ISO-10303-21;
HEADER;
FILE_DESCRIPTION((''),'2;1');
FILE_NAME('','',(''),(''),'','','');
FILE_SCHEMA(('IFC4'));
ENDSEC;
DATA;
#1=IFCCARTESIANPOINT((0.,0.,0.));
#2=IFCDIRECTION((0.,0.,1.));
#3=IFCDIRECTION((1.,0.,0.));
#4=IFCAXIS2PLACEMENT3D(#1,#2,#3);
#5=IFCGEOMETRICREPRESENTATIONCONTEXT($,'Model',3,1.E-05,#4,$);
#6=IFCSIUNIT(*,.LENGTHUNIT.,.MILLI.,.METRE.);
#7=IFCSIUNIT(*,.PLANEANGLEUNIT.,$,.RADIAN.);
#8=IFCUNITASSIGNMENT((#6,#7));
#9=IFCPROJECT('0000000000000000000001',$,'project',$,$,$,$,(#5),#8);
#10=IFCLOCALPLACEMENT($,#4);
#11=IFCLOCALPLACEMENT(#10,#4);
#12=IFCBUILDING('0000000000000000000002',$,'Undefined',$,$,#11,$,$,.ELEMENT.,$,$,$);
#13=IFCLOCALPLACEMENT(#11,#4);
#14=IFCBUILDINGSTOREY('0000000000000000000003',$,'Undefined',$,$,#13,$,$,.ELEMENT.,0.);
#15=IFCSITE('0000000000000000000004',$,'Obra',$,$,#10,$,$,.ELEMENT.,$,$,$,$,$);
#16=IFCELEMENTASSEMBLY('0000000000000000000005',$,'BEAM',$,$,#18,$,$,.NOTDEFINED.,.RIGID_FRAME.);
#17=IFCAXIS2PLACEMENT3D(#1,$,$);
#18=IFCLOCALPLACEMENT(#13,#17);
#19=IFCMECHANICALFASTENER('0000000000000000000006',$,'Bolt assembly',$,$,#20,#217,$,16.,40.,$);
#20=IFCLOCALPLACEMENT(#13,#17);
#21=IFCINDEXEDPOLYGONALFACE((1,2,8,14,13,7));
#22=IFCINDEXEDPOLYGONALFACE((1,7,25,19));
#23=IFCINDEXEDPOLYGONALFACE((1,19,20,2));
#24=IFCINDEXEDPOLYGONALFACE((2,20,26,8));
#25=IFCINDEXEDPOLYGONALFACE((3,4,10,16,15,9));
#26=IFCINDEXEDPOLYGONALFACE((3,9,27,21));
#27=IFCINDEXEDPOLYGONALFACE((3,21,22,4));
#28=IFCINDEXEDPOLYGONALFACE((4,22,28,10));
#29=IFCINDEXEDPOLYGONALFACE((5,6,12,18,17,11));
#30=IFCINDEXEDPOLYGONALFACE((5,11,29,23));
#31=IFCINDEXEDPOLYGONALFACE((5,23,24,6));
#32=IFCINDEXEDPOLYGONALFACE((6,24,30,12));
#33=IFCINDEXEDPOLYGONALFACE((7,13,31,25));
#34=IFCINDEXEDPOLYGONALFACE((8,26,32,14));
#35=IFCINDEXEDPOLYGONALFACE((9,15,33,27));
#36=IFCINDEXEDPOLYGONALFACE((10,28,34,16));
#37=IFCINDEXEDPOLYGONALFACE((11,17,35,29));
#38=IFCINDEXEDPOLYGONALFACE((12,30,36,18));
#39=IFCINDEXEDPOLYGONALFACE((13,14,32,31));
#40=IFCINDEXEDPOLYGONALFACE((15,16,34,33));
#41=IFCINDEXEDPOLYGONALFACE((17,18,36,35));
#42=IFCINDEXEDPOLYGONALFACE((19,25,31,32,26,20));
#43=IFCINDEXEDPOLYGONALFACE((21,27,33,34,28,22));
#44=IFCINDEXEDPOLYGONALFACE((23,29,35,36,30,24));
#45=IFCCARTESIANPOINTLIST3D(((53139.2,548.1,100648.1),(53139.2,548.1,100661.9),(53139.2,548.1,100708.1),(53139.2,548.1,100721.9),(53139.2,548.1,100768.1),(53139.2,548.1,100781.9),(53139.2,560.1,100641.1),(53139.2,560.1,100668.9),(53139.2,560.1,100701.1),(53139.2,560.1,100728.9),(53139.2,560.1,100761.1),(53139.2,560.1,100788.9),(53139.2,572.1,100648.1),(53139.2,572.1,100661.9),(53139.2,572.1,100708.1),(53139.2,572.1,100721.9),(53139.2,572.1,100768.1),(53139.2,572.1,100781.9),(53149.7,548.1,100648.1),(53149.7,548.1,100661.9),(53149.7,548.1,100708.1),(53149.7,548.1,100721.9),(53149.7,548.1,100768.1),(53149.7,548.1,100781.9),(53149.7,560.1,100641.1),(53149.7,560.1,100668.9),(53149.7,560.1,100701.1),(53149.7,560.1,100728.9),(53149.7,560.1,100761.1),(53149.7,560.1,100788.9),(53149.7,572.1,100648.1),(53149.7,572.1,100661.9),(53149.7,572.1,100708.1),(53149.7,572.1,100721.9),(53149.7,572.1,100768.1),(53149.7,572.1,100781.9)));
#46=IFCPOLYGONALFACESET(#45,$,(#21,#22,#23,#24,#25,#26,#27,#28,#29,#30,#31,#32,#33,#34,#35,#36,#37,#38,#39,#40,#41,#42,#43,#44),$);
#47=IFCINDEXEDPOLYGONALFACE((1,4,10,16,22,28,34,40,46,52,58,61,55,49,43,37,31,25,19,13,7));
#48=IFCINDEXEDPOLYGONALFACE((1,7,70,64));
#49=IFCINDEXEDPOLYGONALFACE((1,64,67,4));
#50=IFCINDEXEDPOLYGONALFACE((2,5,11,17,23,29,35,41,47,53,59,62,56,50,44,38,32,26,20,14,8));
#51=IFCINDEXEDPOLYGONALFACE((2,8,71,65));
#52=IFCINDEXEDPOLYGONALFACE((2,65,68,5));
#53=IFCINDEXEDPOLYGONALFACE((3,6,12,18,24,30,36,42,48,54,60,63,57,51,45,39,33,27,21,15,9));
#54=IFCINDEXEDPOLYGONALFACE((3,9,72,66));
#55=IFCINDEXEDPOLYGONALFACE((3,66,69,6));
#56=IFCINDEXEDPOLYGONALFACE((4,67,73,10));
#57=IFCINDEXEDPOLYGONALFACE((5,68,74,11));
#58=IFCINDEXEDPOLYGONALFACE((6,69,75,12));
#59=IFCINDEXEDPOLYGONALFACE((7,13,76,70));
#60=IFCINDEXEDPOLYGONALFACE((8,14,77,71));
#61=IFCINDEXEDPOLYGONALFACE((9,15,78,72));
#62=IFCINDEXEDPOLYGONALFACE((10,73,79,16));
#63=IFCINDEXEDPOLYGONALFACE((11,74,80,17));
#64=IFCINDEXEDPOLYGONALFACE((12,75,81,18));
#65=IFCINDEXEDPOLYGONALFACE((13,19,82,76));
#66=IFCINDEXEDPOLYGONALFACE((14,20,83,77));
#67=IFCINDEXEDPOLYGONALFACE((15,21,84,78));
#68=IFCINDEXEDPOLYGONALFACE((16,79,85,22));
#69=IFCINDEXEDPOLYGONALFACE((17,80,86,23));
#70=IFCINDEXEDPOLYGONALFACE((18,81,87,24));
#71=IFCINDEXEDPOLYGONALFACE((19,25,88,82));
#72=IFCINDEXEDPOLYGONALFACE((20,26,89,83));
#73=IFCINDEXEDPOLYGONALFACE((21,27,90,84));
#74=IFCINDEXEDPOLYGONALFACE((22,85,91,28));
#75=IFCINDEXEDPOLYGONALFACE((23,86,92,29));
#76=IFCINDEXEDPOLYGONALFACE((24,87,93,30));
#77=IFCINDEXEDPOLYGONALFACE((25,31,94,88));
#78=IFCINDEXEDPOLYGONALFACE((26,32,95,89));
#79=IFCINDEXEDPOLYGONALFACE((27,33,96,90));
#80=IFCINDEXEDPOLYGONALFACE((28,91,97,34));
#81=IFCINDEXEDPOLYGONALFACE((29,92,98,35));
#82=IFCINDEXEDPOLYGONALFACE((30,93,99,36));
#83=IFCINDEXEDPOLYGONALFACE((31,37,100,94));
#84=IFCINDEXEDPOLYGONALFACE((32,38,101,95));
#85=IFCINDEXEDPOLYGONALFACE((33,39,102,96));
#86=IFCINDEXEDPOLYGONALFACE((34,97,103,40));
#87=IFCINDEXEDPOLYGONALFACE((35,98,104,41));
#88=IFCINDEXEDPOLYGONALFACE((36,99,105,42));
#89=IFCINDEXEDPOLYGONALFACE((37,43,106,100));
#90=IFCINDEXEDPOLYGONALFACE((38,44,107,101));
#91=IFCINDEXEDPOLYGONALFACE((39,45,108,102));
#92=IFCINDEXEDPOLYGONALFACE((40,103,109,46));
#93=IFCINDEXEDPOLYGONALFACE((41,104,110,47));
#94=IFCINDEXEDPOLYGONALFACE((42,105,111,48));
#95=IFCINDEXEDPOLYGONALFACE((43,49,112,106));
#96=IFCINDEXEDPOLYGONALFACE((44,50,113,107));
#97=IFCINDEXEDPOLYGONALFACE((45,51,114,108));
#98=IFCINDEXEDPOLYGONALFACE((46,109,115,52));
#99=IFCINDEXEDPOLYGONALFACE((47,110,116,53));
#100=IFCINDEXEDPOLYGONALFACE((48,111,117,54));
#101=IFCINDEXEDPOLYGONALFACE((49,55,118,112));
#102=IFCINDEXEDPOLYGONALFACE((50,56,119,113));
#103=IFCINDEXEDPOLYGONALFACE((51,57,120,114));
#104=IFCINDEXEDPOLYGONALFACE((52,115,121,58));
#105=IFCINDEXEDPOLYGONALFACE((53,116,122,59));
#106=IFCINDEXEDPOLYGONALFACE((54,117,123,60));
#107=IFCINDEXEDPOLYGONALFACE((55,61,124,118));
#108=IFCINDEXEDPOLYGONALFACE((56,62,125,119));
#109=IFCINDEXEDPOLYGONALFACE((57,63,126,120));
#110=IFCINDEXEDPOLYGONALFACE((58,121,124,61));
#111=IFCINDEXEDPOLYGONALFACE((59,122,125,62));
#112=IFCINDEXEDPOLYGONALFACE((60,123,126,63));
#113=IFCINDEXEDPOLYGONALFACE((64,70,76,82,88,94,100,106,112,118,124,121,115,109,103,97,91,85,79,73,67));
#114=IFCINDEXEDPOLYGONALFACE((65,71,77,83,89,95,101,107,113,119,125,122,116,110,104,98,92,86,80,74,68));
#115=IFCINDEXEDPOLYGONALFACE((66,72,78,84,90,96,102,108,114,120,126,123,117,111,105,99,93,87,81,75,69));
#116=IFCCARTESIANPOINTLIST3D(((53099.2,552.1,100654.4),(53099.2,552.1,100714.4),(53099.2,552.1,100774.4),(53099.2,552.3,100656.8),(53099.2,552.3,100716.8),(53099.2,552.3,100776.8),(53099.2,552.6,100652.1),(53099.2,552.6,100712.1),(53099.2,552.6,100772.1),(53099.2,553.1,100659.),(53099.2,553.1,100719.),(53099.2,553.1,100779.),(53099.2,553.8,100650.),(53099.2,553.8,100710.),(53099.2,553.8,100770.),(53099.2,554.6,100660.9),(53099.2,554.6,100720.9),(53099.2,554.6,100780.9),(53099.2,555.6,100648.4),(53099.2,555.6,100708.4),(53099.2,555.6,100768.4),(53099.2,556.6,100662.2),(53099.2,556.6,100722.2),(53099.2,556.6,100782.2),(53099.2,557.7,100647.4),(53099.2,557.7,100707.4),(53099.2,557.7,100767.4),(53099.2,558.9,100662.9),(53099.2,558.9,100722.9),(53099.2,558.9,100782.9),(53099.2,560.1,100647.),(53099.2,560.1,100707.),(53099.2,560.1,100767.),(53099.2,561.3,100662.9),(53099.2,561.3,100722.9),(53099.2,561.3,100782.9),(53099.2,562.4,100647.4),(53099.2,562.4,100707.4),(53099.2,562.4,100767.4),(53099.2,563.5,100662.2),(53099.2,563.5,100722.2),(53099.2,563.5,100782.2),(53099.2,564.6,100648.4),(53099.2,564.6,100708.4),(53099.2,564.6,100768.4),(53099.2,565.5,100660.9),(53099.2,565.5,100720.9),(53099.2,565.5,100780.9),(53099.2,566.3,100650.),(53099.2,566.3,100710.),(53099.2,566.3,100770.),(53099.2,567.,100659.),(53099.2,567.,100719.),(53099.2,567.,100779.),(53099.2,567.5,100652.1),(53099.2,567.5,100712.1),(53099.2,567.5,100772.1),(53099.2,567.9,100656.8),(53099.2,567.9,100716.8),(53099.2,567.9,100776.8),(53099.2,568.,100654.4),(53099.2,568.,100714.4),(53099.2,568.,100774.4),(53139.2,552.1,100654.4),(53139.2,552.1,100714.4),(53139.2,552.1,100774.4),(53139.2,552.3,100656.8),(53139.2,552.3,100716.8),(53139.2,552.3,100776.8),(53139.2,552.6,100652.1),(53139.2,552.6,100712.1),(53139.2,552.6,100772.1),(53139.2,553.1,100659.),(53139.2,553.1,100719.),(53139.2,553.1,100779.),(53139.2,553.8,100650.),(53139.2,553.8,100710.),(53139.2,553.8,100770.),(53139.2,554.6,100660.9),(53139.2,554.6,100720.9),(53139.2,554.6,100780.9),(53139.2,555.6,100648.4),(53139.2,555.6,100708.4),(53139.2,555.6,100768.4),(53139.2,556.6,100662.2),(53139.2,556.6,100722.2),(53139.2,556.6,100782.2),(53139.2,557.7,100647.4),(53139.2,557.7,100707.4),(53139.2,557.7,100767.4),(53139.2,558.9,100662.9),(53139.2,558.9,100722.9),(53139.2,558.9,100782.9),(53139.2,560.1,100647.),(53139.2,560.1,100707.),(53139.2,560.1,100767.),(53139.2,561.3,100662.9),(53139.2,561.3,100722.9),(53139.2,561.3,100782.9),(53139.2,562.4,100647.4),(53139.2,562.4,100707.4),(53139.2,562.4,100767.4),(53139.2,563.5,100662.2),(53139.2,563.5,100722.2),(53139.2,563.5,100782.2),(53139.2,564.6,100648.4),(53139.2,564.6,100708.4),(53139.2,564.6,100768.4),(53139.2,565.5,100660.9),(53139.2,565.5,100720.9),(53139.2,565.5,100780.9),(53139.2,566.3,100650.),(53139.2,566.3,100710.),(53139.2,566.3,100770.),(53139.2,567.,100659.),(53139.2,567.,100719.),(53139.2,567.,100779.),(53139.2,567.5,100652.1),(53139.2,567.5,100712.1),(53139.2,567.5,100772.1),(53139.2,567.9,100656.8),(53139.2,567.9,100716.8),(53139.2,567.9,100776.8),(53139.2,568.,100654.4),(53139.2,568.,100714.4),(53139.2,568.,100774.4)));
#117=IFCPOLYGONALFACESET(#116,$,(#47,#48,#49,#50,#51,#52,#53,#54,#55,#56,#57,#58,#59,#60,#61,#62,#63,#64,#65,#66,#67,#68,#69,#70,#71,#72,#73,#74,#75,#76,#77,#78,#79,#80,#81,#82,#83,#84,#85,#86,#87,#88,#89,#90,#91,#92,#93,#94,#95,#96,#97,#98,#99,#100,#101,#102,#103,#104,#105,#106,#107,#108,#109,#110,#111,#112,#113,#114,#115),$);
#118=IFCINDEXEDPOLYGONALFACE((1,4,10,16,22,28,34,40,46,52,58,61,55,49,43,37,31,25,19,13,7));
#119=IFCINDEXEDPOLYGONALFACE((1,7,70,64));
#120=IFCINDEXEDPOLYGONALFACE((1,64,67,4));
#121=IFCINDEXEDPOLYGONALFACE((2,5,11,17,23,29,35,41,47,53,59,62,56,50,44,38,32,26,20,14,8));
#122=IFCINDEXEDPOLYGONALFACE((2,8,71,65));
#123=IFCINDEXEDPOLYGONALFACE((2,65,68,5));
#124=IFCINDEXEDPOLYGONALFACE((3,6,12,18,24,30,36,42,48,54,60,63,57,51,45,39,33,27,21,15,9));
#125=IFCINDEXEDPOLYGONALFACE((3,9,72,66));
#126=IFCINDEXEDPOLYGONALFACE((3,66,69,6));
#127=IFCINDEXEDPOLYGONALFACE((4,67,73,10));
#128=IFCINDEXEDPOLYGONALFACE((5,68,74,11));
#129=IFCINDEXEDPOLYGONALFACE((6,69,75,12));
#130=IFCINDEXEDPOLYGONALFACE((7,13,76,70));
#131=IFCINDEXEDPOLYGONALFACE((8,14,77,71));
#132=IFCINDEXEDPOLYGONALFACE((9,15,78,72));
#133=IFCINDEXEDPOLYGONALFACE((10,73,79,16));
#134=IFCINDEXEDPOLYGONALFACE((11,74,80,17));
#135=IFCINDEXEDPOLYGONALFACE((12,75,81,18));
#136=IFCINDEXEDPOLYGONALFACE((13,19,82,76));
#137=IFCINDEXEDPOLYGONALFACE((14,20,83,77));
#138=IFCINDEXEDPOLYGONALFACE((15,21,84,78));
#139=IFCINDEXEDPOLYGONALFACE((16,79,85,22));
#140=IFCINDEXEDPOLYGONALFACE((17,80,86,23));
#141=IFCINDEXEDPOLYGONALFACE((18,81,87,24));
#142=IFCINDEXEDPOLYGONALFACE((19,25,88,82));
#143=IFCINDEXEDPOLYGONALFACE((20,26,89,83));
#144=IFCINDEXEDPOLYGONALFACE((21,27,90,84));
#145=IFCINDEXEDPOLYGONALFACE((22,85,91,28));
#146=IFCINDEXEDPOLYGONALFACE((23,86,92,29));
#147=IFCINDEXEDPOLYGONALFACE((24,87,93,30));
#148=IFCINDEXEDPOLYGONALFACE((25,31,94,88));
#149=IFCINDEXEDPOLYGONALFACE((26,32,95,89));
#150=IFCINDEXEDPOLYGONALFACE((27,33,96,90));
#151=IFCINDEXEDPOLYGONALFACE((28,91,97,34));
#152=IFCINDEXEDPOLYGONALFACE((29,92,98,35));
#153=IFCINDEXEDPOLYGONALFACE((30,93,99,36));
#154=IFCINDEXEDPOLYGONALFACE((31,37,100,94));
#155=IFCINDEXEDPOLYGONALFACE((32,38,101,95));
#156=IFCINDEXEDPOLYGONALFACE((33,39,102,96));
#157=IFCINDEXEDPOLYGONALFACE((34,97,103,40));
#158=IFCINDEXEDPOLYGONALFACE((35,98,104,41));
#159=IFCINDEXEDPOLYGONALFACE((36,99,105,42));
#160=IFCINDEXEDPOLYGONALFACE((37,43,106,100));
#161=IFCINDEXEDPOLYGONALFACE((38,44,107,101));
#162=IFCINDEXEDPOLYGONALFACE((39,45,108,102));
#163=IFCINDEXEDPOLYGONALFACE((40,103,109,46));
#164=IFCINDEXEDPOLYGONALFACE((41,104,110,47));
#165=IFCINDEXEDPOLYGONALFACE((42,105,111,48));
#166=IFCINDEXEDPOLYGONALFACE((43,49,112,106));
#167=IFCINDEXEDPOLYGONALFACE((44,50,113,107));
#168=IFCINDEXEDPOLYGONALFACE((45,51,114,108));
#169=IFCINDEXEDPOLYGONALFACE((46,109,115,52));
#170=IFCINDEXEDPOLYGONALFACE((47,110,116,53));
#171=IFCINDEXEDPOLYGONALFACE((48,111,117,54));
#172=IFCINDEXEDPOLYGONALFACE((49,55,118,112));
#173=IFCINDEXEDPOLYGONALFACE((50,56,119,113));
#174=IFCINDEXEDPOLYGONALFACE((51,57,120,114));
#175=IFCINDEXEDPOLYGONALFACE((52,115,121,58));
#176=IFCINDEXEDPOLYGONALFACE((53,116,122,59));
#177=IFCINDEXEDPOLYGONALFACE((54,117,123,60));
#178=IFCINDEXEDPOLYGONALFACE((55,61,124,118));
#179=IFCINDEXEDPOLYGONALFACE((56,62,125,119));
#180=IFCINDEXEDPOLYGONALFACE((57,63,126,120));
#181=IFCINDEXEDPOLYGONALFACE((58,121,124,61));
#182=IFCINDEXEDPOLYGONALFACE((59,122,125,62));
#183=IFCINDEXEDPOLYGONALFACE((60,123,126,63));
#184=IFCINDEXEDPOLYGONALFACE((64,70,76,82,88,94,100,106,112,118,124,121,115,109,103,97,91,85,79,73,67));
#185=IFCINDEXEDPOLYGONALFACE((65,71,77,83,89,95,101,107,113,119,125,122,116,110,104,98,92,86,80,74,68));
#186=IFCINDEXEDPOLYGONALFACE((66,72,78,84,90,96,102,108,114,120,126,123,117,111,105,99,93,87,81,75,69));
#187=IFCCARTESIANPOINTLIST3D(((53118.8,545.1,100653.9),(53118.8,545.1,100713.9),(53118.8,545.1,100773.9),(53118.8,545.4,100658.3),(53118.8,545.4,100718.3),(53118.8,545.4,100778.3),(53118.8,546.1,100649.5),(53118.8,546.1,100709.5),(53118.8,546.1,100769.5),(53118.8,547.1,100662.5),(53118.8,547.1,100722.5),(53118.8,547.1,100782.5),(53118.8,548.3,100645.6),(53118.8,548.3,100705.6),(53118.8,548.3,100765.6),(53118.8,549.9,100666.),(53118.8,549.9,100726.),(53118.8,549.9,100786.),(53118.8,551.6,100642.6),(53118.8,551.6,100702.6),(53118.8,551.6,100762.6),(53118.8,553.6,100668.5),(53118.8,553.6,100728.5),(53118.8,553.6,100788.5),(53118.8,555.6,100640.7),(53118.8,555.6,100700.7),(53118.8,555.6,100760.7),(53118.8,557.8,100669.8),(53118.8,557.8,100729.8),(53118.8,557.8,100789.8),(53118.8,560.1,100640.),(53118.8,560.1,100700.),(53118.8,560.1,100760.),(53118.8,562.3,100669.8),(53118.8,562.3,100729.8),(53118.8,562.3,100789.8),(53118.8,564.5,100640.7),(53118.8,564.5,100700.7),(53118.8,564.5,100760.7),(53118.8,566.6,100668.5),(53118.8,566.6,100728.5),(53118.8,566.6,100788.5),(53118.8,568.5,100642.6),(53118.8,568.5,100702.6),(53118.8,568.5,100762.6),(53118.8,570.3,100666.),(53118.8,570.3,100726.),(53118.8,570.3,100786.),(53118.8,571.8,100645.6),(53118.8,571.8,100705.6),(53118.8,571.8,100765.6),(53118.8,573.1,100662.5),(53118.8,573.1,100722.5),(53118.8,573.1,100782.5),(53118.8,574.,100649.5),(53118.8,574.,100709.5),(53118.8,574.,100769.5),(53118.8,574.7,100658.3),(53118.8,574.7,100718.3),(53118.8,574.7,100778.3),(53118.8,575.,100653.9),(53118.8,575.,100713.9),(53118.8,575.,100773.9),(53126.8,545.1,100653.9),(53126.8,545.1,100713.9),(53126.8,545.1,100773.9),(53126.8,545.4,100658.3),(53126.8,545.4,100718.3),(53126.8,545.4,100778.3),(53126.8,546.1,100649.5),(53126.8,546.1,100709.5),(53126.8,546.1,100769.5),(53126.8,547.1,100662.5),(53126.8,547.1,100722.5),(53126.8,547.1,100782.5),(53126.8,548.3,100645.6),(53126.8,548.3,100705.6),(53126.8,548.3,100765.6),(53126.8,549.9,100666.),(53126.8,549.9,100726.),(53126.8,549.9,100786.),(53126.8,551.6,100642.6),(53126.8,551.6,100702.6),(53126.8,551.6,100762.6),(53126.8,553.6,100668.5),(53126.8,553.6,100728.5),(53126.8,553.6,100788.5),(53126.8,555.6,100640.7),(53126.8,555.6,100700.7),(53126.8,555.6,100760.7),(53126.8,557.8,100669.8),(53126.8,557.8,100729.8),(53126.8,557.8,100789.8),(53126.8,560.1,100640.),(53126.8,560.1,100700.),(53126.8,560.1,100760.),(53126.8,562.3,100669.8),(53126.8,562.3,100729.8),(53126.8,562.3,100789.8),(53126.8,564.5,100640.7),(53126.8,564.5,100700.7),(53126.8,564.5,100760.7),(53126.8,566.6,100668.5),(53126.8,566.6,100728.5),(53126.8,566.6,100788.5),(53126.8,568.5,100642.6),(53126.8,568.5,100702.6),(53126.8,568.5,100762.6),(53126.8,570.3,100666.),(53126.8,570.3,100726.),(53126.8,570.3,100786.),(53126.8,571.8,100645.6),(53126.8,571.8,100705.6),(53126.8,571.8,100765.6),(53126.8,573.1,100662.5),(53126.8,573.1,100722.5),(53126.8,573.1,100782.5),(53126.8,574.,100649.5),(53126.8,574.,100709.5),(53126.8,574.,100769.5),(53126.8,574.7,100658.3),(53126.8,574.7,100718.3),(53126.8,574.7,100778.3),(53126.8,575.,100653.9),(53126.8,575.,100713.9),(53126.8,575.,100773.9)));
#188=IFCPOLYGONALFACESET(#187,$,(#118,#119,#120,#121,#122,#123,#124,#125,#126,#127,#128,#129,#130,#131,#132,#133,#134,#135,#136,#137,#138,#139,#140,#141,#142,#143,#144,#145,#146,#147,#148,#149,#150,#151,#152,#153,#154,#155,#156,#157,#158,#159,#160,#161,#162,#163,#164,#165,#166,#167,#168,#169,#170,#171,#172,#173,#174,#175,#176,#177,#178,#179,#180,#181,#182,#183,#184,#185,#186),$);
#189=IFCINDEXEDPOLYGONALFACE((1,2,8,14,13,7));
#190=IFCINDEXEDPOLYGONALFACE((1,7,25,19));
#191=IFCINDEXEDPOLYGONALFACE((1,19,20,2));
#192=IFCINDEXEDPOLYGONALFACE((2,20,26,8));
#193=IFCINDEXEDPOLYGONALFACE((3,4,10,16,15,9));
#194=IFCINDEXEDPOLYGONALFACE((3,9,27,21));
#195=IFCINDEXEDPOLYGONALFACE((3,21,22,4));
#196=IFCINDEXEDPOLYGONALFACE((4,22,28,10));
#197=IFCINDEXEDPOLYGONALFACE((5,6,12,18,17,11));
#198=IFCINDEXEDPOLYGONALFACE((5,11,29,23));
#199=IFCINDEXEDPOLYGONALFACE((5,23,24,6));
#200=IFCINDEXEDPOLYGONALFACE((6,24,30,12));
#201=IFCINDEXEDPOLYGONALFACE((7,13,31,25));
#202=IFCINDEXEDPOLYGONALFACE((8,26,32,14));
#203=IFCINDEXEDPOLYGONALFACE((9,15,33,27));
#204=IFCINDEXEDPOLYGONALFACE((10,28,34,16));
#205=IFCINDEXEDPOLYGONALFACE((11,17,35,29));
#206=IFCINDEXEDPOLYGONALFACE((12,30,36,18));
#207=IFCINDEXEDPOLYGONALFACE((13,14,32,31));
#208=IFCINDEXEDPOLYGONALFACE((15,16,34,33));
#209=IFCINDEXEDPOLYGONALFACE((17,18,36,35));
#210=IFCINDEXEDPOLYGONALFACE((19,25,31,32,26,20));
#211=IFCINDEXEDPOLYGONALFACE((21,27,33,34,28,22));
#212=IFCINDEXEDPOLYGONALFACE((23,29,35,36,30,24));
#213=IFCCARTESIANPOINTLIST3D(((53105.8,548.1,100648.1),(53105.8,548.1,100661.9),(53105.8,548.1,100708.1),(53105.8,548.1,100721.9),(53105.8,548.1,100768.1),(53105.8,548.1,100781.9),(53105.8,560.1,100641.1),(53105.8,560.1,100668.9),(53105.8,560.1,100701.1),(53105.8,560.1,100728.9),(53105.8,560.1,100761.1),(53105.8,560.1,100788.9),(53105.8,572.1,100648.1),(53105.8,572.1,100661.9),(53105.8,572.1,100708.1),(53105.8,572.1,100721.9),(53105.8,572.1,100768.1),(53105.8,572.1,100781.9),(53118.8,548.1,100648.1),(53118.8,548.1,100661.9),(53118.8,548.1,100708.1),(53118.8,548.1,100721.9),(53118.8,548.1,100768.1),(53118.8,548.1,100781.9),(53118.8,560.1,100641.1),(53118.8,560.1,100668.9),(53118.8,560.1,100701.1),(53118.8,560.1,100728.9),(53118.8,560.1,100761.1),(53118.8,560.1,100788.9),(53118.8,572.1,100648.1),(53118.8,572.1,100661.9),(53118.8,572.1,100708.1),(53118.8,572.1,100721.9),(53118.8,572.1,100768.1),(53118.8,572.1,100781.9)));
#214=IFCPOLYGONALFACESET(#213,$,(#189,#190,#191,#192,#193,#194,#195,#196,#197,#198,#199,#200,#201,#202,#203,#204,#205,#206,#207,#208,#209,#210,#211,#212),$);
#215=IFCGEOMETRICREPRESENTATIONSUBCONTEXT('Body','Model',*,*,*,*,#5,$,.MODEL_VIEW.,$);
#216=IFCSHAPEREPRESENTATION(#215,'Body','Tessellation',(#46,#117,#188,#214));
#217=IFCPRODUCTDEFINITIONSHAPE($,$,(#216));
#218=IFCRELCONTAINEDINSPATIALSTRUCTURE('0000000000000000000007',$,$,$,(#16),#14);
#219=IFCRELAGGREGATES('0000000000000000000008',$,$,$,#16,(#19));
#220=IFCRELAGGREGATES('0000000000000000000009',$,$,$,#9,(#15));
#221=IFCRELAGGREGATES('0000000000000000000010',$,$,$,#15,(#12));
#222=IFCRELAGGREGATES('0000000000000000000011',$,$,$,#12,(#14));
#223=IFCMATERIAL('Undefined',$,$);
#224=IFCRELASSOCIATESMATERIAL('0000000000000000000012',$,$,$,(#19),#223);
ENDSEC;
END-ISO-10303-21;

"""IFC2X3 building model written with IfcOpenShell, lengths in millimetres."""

from ifc_helpers import new_model, si_unit, frame, origin_with_axes, origin_2d_with_axis, place, context, subcontext, project, spatial, polyline, circle, outline, extrude, source, transform, mapped, material, element, aggregate, save


model = new_model("IFC2X3")

# Units and contexts
model_context = context("Model", 3, precision=1e-05, world=origin_with_axes())
body_context = subcontext(model_context, "Body", "Model", "MODEL_VIEW")
ifc_project = project(units=[si_unit("LENGTHUNIT", "METRE", prefix="MILLI"), si_unit("PLANEANGLEUNIT", "RADIAN")], contexts=[model_context])

# Site, building, storey
site_placement = place(None, origin_with_axes())
site = spatial("IfcSite", under=ifc_project, at=site_placement, Name="Obra", CompositionType="ELEMENT")
building_placement = place(site_placement, origin_with_axes())
building = spatial("IfcBuilding", under=site, at=building_placement, Name="Undefined", CompositionType="ELEMENT")
storey_placement = place(building_placement, origin_with_axes())
storey = spatial("IfcBuildingStorey", under=building, at=storey_placement, Name="Undefined", CompositionType="ELEMENT", Elevation=0.0)

# Shared definitions
ifc_material_1 = material(Name="Undefined")

# Element assembly, mechanical fastener
shared_shape_1 = source(origin_with_axes(), body_context, "Body", "SweptSolid", [
    extrude(outline(polyline([(13.9, 0.0), (6.9, 12.0), (-6.9, 12.0), (-13.9, 0.0), (-6.9, -12.0), (6.9, -12.0), (13.9, 0.0)])), frame((0.0, -19.7, 0.0), z_axis=(0.0, 1.0, 0.0), x_axis=(1.0, 0.0, 0.0)), (0.0, 0.0, 1.0), 10.6),
    extrude(circle(Radius=8.0, at=origin_2d_with_axis()), frame((0.0, -9.1, 0.0), z_axis=(0.0, 1.0, 0.0), x_axis=(1.0, 0.0, 0.0)), (0.0, 0.0, 1.0), 40.0),
    extrude(circle(Radius=15.0, at=origin_2d_with_axis()), frame((0.0, 3.3, 0.0), z_axis=(0.0, 1.0, 0.0), x_axis=(1.0, 0.0, 0.0)), (0.0, 0.0, 1.0), 8.0),
    extrude(outline(polyline([(13.9, 0.0), (6.9, 12.0), (-6.9, 12.0), (-13.9, 0.0), (-6.9, -12.0), (6.9, -12.0), (13.9, 0.0)])), frame((0.0, 11.3, 0.0), z_axis=(0.0, 1.0, 0.0), x_axis=(1.0, 0.0, 0.0)), (0.0, 0.0, 1.0), 13.0),
])
assembly_1_placement = place(storey_placement, origin_with_axes())
assembly_1 = element("IfcElementAssembly", 1, at=assembly_1_placement, inside=storey, Name="BEAM", AssemblyPlace="NOTDEFINED", PredefinedType="RIGID_FRAME")
mechanical_fastener_1_placement = place(assembly_1_placement, frame((53130.1, 510.1, 100835.0), z_axis=(-0.000002, 1.0, 0.0), x_axis=(0.0, 0.0, -1.0)))
mechanical_fastener_1 = element("IfcMechanicalFastener", 2, at=mechanical_fastener_1_placement, material=ifc_material_1, Name="Bolt assembly", NominalDiameter=16.0, NominalLength=40.0, context=body_context, shape_type="MappedRepresentation", body=[
    mapped(shared_shape_1, transform((60.0, 0.0, 50.0))),
    mapped(shared_shape_1, transform((120.0, 0.0, 50.0))),
    mapped(shared_shape_1, transform((180.0, 0.0, 50.0))),
])

aggregate(assembly_1, [mechanical_fastener_1])

save(model, "model.ifc")
